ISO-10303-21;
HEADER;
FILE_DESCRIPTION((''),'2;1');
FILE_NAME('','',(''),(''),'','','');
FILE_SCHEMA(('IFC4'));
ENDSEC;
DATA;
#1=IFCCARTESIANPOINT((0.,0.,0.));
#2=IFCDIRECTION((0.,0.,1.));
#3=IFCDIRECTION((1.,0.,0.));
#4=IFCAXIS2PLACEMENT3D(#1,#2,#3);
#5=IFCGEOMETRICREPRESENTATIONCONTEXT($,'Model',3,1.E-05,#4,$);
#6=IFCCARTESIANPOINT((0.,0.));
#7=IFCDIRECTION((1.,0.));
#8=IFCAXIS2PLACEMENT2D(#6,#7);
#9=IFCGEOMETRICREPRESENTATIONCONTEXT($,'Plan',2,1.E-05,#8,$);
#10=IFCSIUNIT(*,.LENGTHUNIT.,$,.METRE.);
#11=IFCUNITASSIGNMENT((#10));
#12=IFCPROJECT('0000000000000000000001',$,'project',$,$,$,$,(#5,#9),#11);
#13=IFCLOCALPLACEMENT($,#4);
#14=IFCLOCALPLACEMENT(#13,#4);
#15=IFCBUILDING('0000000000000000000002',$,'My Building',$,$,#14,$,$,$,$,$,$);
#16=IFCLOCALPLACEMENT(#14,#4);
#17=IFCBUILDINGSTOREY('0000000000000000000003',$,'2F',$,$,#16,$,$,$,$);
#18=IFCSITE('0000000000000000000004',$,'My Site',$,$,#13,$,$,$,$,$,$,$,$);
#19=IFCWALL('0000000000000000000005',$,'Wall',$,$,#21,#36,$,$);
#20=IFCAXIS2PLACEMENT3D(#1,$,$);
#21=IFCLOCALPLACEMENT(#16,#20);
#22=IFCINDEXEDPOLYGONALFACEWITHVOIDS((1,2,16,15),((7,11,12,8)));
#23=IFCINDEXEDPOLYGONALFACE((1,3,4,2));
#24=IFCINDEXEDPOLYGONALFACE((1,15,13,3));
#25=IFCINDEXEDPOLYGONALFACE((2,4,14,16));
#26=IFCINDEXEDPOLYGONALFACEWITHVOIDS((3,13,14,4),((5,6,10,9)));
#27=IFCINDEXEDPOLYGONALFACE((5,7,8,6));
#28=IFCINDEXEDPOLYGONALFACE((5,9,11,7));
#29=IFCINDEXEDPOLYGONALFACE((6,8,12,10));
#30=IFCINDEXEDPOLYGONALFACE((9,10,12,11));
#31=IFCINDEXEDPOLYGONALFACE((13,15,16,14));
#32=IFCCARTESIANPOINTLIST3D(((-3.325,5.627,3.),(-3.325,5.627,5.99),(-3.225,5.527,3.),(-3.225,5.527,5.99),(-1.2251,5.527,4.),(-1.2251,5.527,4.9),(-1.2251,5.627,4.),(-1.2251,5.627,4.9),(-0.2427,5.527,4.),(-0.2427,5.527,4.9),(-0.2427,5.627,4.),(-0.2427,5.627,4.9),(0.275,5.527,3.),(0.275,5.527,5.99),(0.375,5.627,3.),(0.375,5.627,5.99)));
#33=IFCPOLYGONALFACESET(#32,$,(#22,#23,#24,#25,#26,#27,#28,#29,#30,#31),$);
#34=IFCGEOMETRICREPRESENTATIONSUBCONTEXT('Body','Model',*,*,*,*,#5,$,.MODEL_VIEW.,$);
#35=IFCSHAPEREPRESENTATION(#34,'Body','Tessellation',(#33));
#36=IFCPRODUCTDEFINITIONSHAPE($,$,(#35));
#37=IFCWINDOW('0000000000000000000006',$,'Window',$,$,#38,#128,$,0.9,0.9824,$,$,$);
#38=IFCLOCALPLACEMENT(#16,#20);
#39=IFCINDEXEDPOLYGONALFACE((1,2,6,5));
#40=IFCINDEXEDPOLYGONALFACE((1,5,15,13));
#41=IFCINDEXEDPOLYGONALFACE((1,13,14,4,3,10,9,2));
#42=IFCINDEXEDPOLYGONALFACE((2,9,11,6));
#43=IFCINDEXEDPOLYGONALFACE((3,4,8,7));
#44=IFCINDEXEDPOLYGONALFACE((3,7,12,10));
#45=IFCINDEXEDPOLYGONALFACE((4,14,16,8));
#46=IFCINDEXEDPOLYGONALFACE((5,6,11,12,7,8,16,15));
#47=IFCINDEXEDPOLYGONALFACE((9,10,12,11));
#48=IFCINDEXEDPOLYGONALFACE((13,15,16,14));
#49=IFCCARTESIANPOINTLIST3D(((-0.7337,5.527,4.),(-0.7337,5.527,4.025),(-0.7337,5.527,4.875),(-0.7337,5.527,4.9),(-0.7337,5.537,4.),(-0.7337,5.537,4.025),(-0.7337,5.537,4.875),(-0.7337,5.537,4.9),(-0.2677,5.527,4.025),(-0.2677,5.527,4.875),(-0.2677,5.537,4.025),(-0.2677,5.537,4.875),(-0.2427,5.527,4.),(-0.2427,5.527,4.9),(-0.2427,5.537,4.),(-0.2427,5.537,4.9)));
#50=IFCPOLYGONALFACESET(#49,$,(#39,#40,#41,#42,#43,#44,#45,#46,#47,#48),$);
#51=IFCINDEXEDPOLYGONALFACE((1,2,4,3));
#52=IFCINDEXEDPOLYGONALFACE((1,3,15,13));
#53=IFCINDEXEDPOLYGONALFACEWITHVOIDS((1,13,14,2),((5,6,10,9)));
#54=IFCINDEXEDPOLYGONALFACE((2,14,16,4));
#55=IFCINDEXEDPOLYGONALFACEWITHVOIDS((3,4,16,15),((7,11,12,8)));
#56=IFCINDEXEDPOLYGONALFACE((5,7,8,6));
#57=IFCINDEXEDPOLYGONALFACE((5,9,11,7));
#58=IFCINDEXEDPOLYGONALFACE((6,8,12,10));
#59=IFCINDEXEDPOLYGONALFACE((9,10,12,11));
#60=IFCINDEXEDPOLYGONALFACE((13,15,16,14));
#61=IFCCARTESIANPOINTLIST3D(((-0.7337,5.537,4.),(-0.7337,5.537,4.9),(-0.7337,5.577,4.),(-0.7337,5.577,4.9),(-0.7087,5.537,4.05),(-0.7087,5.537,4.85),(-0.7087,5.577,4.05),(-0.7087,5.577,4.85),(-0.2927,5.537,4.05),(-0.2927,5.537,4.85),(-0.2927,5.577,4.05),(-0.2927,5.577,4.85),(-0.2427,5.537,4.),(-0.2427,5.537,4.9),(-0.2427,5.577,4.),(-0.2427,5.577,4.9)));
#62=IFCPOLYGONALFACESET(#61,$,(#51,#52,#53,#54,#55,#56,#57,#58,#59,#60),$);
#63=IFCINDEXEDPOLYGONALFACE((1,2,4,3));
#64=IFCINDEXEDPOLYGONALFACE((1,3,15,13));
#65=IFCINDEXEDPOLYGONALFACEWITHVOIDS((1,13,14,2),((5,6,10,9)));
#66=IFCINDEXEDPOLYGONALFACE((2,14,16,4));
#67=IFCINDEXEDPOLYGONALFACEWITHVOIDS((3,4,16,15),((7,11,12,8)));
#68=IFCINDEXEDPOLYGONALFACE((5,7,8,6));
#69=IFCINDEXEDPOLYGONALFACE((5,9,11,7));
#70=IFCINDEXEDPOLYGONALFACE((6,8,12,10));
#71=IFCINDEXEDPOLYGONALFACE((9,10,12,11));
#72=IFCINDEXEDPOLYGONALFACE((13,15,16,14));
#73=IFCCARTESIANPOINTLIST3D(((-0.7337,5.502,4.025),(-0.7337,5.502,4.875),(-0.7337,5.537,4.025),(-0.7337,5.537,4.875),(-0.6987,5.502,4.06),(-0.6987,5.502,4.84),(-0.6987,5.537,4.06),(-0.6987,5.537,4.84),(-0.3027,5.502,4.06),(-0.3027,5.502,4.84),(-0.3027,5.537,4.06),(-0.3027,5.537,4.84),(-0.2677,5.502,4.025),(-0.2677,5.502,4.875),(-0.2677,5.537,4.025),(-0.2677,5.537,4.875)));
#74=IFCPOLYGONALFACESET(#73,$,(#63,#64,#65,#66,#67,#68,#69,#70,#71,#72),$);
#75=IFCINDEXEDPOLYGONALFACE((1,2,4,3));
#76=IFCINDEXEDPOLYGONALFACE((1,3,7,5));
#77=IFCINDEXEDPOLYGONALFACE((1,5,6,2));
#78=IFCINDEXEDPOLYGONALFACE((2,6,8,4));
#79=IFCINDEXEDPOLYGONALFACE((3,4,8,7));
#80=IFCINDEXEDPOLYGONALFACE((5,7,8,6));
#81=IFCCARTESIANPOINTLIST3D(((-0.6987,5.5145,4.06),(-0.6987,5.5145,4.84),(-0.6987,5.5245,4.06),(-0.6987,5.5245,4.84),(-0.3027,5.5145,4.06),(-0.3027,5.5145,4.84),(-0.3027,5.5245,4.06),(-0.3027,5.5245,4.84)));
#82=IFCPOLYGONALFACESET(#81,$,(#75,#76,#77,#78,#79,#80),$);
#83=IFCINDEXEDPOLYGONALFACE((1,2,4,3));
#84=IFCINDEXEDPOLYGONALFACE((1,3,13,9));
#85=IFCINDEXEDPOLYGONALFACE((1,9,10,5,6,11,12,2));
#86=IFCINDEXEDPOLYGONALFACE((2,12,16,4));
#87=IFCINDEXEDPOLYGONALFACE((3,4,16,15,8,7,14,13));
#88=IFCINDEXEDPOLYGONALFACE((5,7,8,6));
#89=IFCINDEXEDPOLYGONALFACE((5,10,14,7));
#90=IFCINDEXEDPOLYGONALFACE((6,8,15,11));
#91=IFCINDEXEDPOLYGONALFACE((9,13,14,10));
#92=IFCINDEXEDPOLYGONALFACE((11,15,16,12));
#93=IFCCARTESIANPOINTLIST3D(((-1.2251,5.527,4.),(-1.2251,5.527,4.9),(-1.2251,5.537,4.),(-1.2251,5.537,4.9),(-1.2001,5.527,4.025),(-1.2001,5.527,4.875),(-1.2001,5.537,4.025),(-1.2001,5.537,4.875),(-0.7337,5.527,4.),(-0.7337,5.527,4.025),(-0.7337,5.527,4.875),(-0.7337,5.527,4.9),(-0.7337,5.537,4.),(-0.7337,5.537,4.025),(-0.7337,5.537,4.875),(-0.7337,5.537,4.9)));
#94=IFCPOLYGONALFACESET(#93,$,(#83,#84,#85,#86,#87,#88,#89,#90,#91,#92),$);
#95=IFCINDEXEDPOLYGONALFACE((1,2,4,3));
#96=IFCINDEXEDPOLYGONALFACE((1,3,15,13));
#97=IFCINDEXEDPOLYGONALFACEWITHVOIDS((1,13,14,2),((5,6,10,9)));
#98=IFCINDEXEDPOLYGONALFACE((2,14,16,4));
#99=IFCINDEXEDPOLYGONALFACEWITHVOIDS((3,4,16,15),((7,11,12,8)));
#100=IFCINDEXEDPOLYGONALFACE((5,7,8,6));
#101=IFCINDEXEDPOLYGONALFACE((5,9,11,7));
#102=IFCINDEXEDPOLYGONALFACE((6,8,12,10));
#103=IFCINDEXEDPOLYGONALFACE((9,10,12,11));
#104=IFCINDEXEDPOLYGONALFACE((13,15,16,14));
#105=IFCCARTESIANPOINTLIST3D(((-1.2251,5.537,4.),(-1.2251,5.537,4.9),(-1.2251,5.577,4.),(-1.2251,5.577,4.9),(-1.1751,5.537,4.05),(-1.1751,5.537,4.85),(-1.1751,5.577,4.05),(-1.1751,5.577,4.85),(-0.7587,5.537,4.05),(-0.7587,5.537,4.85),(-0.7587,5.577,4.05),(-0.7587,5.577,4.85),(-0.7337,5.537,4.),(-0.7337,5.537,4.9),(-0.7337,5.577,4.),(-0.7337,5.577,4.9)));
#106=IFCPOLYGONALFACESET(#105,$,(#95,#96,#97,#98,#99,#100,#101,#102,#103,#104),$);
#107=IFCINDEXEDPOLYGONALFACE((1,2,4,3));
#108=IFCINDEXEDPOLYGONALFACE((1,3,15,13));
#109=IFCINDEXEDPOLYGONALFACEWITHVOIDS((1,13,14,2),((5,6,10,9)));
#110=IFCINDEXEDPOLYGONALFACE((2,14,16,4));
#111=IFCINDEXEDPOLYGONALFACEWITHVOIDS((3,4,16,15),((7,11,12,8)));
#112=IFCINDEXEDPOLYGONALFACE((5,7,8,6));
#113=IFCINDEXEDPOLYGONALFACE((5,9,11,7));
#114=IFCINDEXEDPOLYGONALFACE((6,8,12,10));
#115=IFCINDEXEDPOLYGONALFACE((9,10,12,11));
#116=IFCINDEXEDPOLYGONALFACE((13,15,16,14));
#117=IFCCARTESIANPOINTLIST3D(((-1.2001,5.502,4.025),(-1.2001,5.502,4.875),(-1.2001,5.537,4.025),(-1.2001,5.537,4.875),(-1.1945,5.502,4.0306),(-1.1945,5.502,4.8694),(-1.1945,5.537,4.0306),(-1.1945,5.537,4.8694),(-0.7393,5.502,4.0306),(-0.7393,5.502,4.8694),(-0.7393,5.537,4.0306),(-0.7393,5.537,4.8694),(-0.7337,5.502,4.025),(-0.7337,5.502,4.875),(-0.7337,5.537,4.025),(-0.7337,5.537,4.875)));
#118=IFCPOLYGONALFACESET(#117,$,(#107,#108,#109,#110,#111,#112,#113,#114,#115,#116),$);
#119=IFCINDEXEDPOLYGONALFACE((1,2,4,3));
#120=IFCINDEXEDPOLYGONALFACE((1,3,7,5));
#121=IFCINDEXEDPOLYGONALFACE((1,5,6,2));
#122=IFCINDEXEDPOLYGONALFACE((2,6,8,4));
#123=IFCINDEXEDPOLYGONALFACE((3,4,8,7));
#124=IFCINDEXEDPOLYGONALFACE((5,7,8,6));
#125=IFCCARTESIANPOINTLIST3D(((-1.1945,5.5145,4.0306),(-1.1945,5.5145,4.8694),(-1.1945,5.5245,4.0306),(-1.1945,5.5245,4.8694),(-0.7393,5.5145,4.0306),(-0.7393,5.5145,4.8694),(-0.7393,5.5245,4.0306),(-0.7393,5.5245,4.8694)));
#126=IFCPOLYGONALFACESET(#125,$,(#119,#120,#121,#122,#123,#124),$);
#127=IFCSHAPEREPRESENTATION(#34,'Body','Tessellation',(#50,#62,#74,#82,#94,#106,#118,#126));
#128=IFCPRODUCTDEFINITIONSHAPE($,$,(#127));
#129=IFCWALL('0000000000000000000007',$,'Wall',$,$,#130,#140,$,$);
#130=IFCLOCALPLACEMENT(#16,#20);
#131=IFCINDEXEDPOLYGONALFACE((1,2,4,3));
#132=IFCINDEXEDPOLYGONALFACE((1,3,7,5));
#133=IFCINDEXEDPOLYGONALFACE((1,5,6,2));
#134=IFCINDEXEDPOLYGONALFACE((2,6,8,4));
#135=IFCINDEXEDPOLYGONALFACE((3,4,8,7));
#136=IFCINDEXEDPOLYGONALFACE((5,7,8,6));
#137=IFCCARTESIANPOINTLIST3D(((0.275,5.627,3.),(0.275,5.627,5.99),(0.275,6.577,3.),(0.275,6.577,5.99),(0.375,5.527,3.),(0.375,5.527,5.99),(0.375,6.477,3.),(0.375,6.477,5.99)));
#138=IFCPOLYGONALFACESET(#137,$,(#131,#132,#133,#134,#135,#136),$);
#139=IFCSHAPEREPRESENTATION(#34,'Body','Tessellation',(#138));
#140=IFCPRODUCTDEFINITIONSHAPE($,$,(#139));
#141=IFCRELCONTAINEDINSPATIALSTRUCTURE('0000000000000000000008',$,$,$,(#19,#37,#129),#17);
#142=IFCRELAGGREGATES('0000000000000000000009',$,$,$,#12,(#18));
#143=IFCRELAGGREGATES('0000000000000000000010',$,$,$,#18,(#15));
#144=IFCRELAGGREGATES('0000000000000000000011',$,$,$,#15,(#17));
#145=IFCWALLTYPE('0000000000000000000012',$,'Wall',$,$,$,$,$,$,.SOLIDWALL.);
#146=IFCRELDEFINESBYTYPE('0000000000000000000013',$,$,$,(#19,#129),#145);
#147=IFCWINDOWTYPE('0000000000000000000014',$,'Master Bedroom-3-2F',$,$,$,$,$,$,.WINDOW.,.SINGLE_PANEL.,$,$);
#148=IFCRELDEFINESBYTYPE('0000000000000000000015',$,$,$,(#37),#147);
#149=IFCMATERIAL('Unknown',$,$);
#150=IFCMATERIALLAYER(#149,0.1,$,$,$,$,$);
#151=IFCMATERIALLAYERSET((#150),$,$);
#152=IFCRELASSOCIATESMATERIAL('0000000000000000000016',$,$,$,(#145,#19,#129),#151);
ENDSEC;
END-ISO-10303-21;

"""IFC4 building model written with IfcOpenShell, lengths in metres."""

from ifc_helpers import new_model, entity, si_unit, frame, origin_with_axes, origin_2d_with_axis, place, context, subcontext, project, spatial, line, indexed_curve, outline, extrude, shape, source, transform, mapped, material, layer, layer_set, layer_usage, type_object, type_shapes, element, fill, save


model = new_model("IFC4")

# Units and contexts
model_context = context("Model", 3, precision=1e-05, world=origin_with_axes())
plan_context = context("Plan", 2, precision=1e-05, world=origin_2d_with_axis())
body_context_1 = subcontext(model_context, "Body", "Model", "MODEL_VIEW")
body_context_2 = subcontext(plan_context, "Body", "Plan", "PLAN_VIEW")
ifc_project = project(units=[si_unit("LENGTHUNIT", "METRE")], contexts=[model_context, plan_context])

# Site, building, storey
site_placement = place(None, origin_with_axes())
site = spatial("IfcSite", under=ifc_project, at=site_placement, Name="My Site")
building_placement = place(site_placement, origin_with_axes())
building = spatial("IfcBuilding", under=site, at=building_placement, Name="My Building")
storey_placement = place(building_placement, origin_with_axes())
storey = spatial("IfcBuildingStorey", under=building, at=storey_placement, Name="2F")

# Shared definitions
ifc_material = material(Name="Unknown")

# Shared definitions
ifc_layer_1 = layer(ifc_material, 0.1)
ifc_layer_set_1 = layer_set([ifc_layer_1])
wall_type = type_object("IfcWallType", Name="Wall", PredefinedType="SOLIDWALL", material=ifc_layer_set_1)

# Wall, opening, window
ifc_layer_usage_1 = layer_usage(ifc_layer_set_1, "AXIS2", "POSITIVE", 0.0)
wall_1_placement = place(storey_placement, frame((0.275, 5.627, 3.0), z_axis=(0.0, 0.0, 1.0), x_axis=(-1.0, 0.0, 0.0)))
wall_1 = element("IfcWall", 1, at=wall_1_placement, inside=storey, type_object=wall_type, material=ifc_layer_usage_1, Name="Wall", context=body_context_1, shape_type="SweptSolid", body=[
    extrude(outline(indexed_curve([(-0.1, 0.0), (0.0, 0.1), (3.5, 0.1), (3.6, 0.0)], segments=[line(1, 2, 3, 4, 1)])), origin_with_axes(), (0.0, 0.0, 1.0), 2.99),
])
shared_shape_1 = source(origin_with_axes(), body_context_1, "Body", "SweptSolid", [
    extrude(outline(indexed_curve([(0.0, 0.0), (0.9824, 0.0), (0.9824, 0.9), (0.0, 0.9)], segments=[line(1, 2, 3, 4, 1)])), frame((0.0, -0.6, 0.0), z_axis=(0.0, -1.0, 0.0), x_axis=(1.0, 0.0, 0.0)), (0.0, 0.0, -1.0), 1.2),
])
opening_1_placement = place(wall_1_placement, frame((0.5177, 0.0, 1.0), z_axis=(0.0, 0.0, 1.0), x_axis=(1.0, 0.0, 0.0)))
opening_1 = element("IfcOpeningElement", 2, at=opening_1_placement, cuts=wall_1, PredefinedType="OPENING", context=body_context_1, shape_type="MappedRepresentation", body=[
    mapped(shared_shape_1, transform((0.0, 0.0, 0.0), x_axis=(1.0, 0.0, 0.0), y_axis=(0.0, 1.0, 0.0), z_axis=(0.0, 0.0, 1.0), scale=1.0)),
])
window_type_1 = type_object("IfcWindowType", Name="Master Bedroom-3-2F", PartitioningType="SINGLE_PANEL", PredefinedType="WINDOW")
shared_shape_2 = source(origin_with_axes(), body_context_1, "Body", "SweptSolid", [
    extrude(outline(indexed_curve([(0.4911, 0.0), (0.0, 0.0), (0.0, 0.9), (0.4911, 0.9), (0.4911, 0.875), (0.025, 0.875), (0.025, 0.025), (0.4911, 0.025)], segments=[line(1, 2, 3, 4, 5, 6, 7, 8, 1)])), frame((0.0, 0.09, 0.0), z_axis=(0.0, -1.0, 0.0), x_axis=(1.0, 0.0, 0.0)), (0.0, 0.0, -1.0), 0.01),
    extrude(outline(indexed_curve([(0.0, 0.0), (0.4911, 0.0), (0.4911, 0.9), (0.0, 0.9)], segments=[line(1, 2, 3, 4, 1)]), holes=[indexed_curve([(0.05, 0.05), (0.4661, 0.05), (0.4661, 0.85), (0.05, 0.85)], segments=[line(1, 2, 3, 4, 1)])]), frame((0.0, 0.05, 0.0), z_axis=(0.0, -1.0, 0.0), x_axis=(1.0, 0.0, 0.0)), (0.0, 0.0, -1.0), 0.04),
    extrude(outline(indexed_curve([(0.0, 0.0), (0.4661, 0.0), (0.4661, 0.85), (0.0, 0.85)], segments=[line(1, 2, 3, 4, 1)]), holes=[indexed_curve([(0.035, 0.035), (0.4311, 0.035), (0.4311, 0.815), (0.035, 0.815)], segments=[line(1, 2, 3, 4, 1)])]), frame((0.025, 0.09, 0.025), z_axis=(0.0, -1.0, 0.0), x_axis=(1.0, 0.0, 0.0)), (0.0, 0.0, -1.0), 0.035),
    extrude(outline(indexed_curve([(0.035, 0.035), (0.4311, 0.035), (0.4311, 0.815), (0.035, 0.815)], segments=[line(1, 2, 3, 4, 1)])), frame((0.025, 0.1025, 0.025), z_axis=(0.0, -1.0, 0.0), x_axis=(1.0, 0.0, 0.0)), (0.0, 0.0, -1.0), 0.01),
    extrude(outline(indexed_curve([(0.0, 0.9), (0.4913, 0.9), (0.4913, 0.0), (0.0, 0.0), (0.0, 0.025), (0.4663, 0.025), (0.4663, 0.875), (0.0, 0.875)], segments=[line(1, 2, 3, 4, 5, 6, 7, 8, 1)])), frame((0.4911, 0.09, 0.0), z_axis=(0.0, -1.0, 0.0), x_axis=(1.0, 0.0, 0.0)), (0.0, 0.0, -1.0), 0.01),
    extrude(outline(indexed_curve([(0.0, 0.0), (0.4913, 0.0), (0.4913, 0.9), (0.0, 0.9)], segments=[line(1, 2, 3, 4, 1)]), holes=[indexed_curve([(0.025, 0.05), (0.4413, 0.05), (0.4413, 0.85), (0.025, 0.85)], segments=[line(1, 2, 3, 4, 1)])]), frame((0.4911, 0.05, 0.0), z_axis=(0.0, -1.0, 0.0), x_axis=(1.0, 0.0, 0.0)), (0.0, 0.0, -1.0), 0.04),
    extrude(outline(indexed_curve([(0.0, 0.0), (0.4663, 0.0), (0.4663, 0.85), (0.0, 0.85)], segments=[line(1, 2, 3, 4, 1)]), holes=[indexed_curve([(0.0056, 0.0056), (0.4608, 0.0056), (0.4608, 0.8444), (0.0056, 0.8444)], segments=[line(1, 2, 3, 4, 1)])]), frame((0.4911, 0.09, 0.025), z_axis=(0.0, -1.0, 0.0), x_axis=(1.0, 0.0, 0.0)), (0.0, 0.0, -1.0), 0.035),
    extrude(outline(indexed_curve([(0.0056, 0.0056), (0.4608, 0.0056), (0.4608, 0.8444), (0.0056, 0.8444)], segments=[line(1, 2, 3, 4, 1)])), frame((0.4911, 0.1025, 0.025), z_axis=(0.0, -1.0, 0.0), x_axis=(1.0, 0.0, 0.0)), (0.0, 0.0, -1.0), 0.01),
])
shared_shape_3 = source(origin_with_axes(), body_context_2, "Body", "Curve2D", [
    entity("IfcIndexedPolyCurve", entity("IfcCartesianPointList2D", [[0.05, 0.05], [0.4661, 0.05]])),
    entity("IfcIndexedPolyCurve", entity("IfcCartesianPointList2D", [[0.0, 0.1], [0.025, 0.1], [0.025, 0.09], [0.05, 0.09], [0.05, 0.05], [0.0, 0.05]]), [entity("IfcLineIndex", [1, 2, 3, 4, 5, 6, 1])]),
    entity("IfcIndexedPolyCurve", entity("IfcCartesianPointList2D", [[0.4911, 0.1], [0.4911, 0.1], [0.4911, 0.09], [0.4661, 0.09], [0.4661, 0.05], [0.4911, 0.05]])),
    entity("IfcIndexedPolyCurve", entity("IfcCartesianPointList2D", [[0.025, 0.09], [0.06, 0.09], [0.06, 0.125], [0.025, 0.125]]), [entity("IfcLineIndex", [1, 2, 3, 4, 1])]),
    entity("IfcIndexedPolyCurve", entity("IfcCartesianPointList2D", [[0.4911, 0.09], [0.4561, 0.09], [0.4561, 0.125], [0.4911, 0.125]]), [entity("IfcLineIndex", [1, 2, 3, 4, 1])]),
    entity("IfcIndexedPolyCurve", entity("IfcCartesianPointList2D", [[0.06, 0.09], [0.4561, 0.09]])),
    entity("IfcIndexedPolyCurve", entity("IfcCartesianPointList2D", [[0.06, 0.125], [0.4561, 0.125]])),
    entity("IfcIndexedPolyCurve", entity("IfcCartesianPointList2D", [[0.06, 0.1075], [0.4561, 0.1075]])),
    entity("IfcIndexedPolyCurve", entity("IfcCartesianPointList2D", [[0.5161, 0.05], [0.9324, 0.05]])),
    entity("IfcIndexedPolyCurve", entity("IfcCartesianPointList2D", [[0.4911, 0.1], [0.4911, 0.1], [0.4911, 0.09], [0.5161, 0.09], [0.5161, 0.05], [0.4911, 0.05]])),
    entity("IfcIndexedPolyCurve", entity("IfcCartesianPointList2D", [[0.9824, 0.1], [0.9574, 0.1], [0.9574, 0.09], [0.9324, 0.09], [0.9324, 0.05], [0.9824, 0.05]]), [entity("IfcLineIndex", [1, 2, 3, 4, 5, 6, 1])]),
    entity("IfcIndexedPolyCurve", entity("IfcCartesianPointList2D", [[0.4911, 0.09], [0.4966, 0.09], [0.4966, 0.125], [0.4911, 0.125]]), [entity("IfcLineIndex", [1, 2, 3, 4, 1])]),
    entity("IfcIndexedPolyCurve", entity("IfcCartesianPointList2D", [[0.9574, 0.09], [0.9519, 0.09], [0.9519, 0.125], [0.9574, 0.125]]), [entity("IfcLineIndex", [1, 2, 3, 4, 1])]),
    entity("IfcIndexedPolyCurve", entity("IfcCartesianPointList2D", [[0.4966, 0.09], [0.9519, 0.09]])),
    entity("IfcIndexedPolyCurve", entity("IfcCartesianPointList2D", [[0.4966, 0.125], [0.9519, 0.125]])),
    entity("IfcIndexedPolyCurve", entity("IfcCartesianPointList2D", [[0.4966, 0.1075], [0.9519, 0.1075]])),
])
type_shapes(window_type_1, [shared_shape_2, shared_shape_3])
window_1_placement = place(opening_1_placement, frame((0.0, 0.0, 0.0), z_axis=(0.0, 0.0, 1.0), x_axis=(1.0, 0.0, 0.0)))
window_1 = element("IfcWindow", 3, at=window_1_placement, inside=storey, type_object=window_type_1, Name="Window", OverallHeight=0.9, OverallWidth=0.9824, shapes=[
    shape(body_context_1, "Body", "MappedRepresentation", [mapped(shared_shape_2, transform((0.0, 0.0, 0.0), x_axis=(1.0, 0.0, 0.0), y_axis=(0.0, 1.0, 0.0), z_axis=(0.0, 0.0, 1.0), scale=1.0))]),
    shape(body_context_2, "Body", "MappedRepresentation", [mapped(shared_shape_3, transform((0.0, 0.0, 0.0), x_axis=(1.0, 0.0, 0.0), y_axis=(0.0, 1.0, 0.0), z_axis=(0.0, 0.0, 1.0), scale=1.0))]),
])
fill(opening_1, window_1)

# Wall
ifc_layer_usage_2 = layer_usage(ifc_layer_set_1, "AXIS2", "POSITIVE", 0.0)
wall_2_placement = place(storey_placement, frame((0.375, 5.627, 3.0), z_axis=(0.0, 0.0, 1.0), x_axis=(0.0, 1.0, 0.0)))
element("IfcWall", 4, at=wall_2_placement, inside=storey, type_object=wall_type, material=ifc_layer_usage_2, Name="Wall", context=body_context_1, shape_type="SweptSolid", body=[
    extrude(outline(indexed_curve([(-0.1, 0.0), (0.0, 0.1), (0.95, 0.1), (0.85, 0.0)], segments=[line(1, 2, 3, 4, 1)])), origin_with_axes(), (0.0, 0.0, 1.0), 2.99),
])

save(model, "model.ifc")
